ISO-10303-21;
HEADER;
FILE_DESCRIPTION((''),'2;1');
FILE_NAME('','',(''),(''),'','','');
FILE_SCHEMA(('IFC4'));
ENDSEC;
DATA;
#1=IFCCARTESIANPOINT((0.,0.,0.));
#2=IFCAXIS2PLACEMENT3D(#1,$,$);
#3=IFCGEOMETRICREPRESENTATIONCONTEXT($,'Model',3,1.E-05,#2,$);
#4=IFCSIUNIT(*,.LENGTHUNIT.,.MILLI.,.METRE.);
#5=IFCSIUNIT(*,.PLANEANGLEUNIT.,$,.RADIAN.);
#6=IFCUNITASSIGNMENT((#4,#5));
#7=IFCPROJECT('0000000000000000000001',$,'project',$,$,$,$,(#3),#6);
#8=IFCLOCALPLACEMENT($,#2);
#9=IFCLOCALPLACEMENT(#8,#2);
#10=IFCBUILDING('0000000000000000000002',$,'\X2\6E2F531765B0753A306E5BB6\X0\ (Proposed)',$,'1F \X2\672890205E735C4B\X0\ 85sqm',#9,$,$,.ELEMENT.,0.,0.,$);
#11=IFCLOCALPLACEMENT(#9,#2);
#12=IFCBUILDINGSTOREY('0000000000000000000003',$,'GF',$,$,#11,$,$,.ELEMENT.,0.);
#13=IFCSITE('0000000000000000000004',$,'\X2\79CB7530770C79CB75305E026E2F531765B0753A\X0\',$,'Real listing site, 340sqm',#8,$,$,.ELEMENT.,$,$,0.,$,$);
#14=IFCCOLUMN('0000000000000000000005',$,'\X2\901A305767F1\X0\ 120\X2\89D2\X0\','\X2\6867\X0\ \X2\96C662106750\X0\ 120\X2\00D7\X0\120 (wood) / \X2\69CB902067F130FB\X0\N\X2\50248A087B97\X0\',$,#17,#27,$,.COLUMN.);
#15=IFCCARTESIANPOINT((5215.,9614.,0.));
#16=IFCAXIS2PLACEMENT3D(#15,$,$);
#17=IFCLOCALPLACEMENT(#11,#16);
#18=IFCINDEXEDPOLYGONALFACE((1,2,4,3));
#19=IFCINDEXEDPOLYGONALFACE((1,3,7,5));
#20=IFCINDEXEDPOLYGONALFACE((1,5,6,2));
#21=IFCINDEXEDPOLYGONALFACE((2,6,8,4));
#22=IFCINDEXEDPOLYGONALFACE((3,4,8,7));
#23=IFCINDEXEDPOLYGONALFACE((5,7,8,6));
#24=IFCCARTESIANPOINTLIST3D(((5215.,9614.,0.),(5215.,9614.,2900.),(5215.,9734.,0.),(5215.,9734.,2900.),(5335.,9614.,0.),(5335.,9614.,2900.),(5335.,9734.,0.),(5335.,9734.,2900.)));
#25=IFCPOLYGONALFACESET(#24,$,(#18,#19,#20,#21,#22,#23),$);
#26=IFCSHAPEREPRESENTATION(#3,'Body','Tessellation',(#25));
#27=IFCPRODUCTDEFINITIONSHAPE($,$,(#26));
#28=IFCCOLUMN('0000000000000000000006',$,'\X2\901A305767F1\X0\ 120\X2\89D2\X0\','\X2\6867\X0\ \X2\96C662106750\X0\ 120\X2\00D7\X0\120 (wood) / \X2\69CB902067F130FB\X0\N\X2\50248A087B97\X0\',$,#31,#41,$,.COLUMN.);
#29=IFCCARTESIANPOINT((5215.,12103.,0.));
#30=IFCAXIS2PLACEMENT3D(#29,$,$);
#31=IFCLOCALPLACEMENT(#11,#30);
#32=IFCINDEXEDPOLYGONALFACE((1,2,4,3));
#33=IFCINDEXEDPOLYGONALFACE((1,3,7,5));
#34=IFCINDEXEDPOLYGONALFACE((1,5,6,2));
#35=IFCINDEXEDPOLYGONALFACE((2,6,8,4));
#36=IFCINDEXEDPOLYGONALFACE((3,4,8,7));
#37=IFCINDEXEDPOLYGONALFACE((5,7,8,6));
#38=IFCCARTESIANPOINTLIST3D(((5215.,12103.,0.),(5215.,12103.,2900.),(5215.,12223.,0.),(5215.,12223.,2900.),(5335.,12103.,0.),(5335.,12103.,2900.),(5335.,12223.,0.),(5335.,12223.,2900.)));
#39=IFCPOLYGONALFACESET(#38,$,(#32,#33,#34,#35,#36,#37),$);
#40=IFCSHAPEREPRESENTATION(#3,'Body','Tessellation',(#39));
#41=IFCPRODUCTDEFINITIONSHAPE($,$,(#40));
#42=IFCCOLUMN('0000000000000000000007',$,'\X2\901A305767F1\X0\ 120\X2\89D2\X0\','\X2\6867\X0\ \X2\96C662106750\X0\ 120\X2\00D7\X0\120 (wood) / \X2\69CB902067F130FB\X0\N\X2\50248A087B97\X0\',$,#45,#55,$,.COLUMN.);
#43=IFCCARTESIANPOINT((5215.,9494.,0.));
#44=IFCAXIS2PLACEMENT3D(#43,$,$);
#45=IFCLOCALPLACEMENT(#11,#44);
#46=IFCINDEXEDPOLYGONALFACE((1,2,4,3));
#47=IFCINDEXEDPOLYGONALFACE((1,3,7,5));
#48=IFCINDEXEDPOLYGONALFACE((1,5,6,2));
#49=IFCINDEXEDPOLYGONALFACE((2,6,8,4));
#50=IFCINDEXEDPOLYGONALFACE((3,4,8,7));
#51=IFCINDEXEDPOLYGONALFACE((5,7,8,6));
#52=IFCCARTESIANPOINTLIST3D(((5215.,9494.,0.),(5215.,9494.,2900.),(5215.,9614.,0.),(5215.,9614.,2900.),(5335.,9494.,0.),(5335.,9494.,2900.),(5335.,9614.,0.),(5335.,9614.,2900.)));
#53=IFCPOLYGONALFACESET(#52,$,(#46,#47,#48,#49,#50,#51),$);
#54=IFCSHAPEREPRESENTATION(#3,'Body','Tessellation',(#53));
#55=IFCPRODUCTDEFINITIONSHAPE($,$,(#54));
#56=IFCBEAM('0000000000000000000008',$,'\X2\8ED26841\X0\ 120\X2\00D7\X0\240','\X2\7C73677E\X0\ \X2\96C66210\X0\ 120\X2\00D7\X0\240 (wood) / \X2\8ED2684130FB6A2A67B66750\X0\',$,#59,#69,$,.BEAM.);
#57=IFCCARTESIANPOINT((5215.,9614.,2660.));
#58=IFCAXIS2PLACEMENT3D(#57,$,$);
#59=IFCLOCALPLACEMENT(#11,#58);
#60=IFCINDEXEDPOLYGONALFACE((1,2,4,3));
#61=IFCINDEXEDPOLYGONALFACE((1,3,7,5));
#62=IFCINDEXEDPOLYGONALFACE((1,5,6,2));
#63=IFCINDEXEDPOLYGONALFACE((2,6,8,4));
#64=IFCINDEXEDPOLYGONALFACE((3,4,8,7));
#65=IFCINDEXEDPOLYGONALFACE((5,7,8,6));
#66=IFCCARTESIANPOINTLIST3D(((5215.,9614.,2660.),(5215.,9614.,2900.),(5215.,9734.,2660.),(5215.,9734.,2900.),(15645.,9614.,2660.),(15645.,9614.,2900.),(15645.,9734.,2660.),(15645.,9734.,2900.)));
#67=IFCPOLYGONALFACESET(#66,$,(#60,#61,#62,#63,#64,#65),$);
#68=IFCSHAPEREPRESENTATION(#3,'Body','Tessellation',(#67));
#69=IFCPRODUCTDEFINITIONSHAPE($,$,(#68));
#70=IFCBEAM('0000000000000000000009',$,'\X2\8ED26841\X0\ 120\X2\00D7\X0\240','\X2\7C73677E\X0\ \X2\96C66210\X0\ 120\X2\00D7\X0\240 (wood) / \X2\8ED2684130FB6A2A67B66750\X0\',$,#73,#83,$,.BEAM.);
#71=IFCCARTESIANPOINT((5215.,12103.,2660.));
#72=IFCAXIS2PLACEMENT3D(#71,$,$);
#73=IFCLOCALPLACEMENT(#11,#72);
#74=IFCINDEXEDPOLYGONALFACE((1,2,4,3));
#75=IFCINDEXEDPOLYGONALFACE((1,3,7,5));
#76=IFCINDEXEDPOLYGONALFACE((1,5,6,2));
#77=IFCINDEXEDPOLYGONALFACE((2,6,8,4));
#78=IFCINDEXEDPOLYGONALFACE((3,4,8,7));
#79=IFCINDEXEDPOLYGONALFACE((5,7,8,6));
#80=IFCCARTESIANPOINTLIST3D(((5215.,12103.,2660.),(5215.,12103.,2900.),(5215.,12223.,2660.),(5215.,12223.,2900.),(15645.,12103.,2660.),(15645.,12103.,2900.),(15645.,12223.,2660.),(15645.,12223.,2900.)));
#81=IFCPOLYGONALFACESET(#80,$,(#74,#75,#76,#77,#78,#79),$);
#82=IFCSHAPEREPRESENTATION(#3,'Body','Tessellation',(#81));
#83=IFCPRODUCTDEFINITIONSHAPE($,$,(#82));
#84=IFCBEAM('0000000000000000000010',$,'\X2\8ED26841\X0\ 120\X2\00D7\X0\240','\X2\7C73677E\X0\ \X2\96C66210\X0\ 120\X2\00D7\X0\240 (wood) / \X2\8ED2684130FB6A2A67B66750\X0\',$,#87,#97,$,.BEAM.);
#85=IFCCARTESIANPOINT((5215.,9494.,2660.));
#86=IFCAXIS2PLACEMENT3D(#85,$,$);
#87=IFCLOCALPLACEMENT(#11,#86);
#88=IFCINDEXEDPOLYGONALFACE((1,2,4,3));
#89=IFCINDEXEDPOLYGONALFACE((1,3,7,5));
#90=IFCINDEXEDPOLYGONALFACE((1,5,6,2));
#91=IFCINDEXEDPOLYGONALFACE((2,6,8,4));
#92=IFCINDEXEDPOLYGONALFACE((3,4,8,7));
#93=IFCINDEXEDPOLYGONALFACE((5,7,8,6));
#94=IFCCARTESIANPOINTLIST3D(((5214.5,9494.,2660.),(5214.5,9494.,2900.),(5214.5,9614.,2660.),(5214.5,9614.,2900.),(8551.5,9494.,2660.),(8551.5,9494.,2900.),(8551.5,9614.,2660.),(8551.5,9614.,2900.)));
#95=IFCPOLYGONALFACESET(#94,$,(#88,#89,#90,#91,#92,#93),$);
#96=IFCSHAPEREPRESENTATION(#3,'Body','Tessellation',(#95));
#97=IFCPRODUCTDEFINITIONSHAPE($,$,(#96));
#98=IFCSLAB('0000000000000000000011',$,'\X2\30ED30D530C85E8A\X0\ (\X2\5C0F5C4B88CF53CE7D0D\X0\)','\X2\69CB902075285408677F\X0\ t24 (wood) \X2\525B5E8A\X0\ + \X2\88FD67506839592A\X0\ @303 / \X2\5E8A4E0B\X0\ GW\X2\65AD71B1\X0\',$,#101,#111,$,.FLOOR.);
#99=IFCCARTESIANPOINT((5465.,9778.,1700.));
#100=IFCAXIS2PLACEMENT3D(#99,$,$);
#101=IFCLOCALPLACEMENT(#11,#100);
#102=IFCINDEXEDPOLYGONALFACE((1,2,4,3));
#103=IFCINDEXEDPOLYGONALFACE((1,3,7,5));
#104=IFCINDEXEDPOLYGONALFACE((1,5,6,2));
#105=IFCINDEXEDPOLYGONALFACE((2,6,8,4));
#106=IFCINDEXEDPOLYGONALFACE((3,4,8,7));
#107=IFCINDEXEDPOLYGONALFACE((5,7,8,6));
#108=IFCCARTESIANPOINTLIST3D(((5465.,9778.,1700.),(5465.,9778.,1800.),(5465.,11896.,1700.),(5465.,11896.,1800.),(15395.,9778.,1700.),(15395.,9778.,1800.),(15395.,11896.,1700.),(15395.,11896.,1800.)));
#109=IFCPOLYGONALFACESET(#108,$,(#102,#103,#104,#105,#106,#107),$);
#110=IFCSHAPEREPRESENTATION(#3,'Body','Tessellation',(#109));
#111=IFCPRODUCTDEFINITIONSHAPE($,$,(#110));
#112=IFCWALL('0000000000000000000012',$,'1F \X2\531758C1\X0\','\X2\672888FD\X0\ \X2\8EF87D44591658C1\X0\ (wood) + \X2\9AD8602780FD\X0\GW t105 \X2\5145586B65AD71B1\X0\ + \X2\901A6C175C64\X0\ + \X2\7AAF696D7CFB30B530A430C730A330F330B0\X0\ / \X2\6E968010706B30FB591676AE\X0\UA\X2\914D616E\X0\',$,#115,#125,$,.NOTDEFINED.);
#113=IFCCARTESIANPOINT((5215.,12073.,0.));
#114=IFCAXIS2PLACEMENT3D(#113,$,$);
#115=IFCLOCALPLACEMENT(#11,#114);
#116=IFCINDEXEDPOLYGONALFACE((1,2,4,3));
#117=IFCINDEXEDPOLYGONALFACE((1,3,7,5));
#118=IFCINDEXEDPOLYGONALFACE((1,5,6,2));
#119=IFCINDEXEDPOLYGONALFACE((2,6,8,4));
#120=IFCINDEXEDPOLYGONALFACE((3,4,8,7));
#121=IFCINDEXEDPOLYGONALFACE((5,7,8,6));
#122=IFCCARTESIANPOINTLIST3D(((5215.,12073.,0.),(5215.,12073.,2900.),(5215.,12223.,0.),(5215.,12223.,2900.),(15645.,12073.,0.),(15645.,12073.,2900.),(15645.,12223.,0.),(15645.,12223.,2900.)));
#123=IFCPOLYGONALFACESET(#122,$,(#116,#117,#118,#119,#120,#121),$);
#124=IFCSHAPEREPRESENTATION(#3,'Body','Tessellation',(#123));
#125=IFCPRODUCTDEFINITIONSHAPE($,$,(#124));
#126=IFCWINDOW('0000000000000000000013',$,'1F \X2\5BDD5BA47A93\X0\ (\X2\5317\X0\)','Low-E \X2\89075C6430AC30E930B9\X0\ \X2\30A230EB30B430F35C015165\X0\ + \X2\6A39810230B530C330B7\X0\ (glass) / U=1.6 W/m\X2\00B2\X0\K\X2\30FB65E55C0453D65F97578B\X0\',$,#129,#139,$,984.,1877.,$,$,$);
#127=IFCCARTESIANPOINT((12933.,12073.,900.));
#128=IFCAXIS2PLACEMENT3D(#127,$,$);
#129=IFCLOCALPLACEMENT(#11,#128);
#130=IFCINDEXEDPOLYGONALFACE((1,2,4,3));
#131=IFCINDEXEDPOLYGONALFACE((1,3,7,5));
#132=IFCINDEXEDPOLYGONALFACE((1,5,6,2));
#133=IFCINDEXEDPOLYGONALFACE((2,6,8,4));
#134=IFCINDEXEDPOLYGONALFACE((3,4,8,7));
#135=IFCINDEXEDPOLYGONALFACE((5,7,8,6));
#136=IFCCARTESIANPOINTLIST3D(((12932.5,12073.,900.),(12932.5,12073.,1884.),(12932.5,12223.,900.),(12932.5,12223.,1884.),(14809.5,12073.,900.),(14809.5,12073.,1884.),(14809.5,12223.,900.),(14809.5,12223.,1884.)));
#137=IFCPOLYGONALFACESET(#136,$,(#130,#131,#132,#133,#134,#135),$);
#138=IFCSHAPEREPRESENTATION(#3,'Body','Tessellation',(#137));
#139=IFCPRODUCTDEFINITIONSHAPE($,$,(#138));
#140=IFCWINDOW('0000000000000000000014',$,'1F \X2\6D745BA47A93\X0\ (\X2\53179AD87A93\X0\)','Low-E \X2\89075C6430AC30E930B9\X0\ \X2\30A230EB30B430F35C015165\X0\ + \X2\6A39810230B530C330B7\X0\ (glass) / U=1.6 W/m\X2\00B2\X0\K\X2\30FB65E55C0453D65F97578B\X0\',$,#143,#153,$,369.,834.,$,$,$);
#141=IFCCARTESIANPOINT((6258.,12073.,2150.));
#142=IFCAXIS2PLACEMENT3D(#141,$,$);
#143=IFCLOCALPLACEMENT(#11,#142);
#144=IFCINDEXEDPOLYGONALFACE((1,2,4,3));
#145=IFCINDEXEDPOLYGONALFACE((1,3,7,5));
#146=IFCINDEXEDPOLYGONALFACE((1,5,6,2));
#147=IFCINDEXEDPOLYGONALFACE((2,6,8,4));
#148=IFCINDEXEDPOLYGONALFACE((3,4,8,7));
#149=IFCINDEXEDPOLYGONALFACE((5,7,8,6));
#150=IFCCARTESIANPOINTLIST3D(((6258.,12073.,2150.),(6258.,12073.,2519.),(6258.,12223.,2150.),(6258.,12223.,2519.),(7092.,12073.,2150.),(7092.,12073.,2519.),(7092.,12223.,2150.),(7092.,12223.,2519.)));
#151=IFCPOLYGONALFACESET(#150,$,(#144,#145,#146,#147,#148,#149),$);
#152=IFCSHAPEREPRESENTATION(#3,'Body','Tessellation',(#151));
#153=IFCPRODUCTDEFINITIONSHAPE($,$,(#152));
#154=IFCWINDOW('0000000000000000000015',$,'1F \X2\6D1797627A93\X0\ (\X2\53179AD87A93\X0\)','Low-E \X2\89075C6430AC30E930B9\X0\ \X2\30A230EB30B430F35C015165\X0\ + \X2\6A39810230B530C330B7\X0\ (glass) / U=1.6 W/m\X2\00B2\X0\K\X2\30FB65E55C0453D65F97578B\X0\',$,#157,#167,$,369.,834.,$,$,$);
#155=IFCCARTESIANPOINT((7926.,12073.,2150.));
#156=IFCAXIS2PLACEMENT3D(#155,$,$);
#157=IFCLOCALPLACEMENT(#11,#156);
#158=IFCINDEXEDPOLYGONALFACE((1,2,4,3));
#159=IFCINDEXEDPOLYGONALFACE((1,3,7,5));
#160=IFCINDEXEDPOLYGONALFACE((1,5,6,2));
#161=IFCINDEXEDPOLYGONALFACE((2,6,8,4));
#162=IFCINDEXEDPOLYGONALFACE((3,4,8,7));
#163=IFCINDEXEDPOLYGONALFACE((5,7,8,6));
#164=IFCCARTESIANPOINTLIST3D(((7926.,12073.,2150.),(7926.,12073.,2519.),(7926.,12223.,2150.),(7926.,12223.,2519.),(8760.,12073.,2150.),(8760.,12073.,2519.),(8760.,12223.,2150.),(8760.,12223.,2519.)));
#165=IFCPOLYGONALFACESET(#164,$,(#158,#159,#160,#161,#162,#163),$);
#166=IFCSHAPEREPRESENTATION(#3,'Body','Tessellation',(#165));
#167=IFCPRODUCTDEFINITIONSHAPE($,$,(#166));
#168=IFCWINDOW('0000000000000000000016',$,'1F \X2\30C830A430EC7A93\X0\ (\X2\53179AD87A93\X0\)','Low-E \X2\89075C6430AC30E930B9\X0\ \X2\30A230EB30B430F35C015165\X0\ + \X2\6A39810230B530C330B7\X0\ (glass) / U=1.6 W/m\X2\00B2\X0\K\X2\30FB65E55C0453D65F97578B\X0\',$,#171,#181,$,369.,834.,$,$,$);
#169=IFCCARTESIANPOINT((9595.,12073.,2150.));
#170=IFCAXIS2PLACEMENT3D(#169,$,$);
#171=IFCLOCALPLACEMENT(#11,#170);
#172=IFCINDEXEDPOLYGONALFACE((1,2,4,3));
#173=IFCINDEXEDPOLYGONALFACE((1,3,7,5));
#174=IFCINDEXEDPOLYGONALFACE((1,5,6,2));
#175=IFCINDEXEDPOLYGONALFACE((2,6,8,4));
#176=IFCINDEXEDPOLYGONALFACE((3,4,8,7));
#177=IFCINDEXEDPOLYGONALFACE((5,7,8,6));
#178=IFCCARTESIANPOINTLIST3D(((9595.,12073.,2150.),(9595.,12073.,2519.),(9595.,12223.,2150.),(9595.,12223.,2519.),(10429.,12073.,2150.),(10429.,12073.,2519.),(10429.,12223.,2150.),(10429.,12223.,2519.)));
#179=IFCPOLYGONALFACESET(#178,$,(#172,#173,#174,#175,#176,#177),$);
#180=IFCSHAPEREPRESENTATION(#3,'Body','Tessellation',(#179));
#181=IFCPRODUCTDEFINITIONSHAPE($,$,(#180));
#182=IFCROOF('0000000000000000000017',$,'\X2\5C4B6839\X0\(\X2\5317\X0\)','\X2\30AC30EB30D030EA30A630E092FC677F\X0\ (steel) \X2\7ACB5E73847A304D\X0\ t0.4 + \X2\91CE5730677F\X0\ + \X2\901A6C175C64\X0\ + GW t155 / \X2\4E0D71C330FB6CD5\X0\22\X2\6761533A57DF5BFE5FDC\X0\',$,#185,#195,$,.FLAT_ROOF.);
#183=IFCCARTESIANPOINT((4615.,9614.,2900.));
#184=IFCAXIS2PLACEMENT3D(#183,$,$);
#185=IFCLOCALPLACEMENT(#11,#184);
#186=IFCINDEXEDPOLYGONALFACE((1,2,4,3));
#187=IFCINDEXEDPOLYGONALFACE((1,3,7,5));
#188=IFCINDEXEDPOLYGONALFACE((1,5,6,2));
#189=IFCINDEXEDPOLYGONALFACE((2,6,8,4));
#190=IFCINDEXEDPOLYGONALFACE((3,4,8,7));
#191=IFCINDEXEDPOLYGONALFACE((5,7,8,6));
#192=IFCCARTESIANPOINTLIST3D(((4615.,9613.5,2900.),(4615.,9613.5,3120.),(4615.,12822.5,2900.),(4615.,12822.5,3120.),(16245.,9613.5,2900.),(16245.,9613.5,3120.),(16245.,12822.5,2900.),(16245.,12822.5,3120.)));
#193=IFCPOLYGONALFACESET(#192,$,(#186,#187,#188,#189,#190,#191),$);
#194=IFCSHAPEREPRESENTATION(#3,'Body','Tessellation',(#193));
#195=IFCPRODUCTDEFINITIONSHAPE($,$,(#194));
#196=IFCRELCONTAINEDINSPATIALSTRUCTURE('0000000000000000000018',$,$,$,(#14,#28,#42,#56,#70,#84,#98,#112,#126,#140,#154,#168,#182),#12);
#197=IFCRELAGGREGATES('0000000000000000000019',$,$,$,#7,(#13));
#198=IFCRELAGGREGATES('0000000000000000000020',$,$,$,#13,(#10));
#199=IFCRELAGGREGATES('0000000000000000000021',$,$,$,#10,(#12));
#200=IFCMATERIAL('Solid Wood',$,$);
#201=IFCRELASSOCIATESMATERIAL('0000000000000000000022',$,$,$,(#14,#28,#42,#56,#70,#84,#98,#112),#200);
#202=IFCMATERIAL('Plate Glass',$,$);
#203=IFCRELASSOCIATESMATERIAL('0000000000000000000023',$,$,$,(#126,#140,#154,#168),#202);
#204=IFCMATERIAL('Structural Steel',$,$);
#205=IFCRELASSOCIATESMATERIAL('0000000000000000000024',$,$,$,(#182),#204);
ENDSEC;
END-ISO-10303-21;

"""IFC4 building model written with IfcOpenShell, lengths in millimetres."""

from ifc_helpers import new_model, si_unit, frame, frame_2d, origin, place, context, project, spatial, rectangle, extrude, material, element, fill, save


model = new_model("IFC4")

# Units and contexts
model_context = context("Model", 3, precision=1e-05, world=origin())
ifc_project = project(units=[si_unit("LENGTHUNIT", "METRE", prefix="MILLI"), si_unit("PLANEANGLEUNIT", "RADIAN")], contexts=[model_context])

# Site, building, storey
site_placement = place(None, origin())
site = spatial("IfcSite", under=ifc_project, at=site_placement, Name="秋田県秋田市港北新町", ObjectType="Real listing site, 340sqm", CompositionType="ELEMENT", RefElevation=0.0)
building_placement = place(site_placement, origin())
building = spatial("IfcBuilding", under=site, at=building_placement, Name="港北新町の家 (Proposed)", ObjectType="1F 木造平屋 85sqm", CompositionType="ELEMENT", ElevationOfRefHeight=0.0, ElevationOfTerrain=0.0)
storey_placement = place(building_placement, origin())
storey = spatial("IfcBuildingStorey", under=building, at=storey_placement, Name="GF", CompositionType="ELEMENT", Elevation=0.0)

# Columns
ifc_material_1 = material(Name="Solid Wood")
column_1_placement = place(storey_placement, frame((5215.0, 9614.0, 0.0)))
element("IfcColumn", 1, at=column_1_placement, inside=storey, material=ifc_material_1, Name="通し柱 120角", Description="桧 集成材 120×120 (wood) / 構造柱・N値計算", PredefinedType="COLUMN", context=model_context, shape_type="SweptSolid", body=[
    extrude(rectangle(XDim=120.0, YDim=120.0, at=frame_2d((60.0, 60.0))), frame((5215.0, 9614.0, 0.0)), (0.0, 0.0, 1.0), 2900.0),
])
column_2_placement = place(storey_placement, frame((5215.0, 12103.0, 0.0)))
element("IfcColumn", 2, at=column_2_placement, inside=storey, material=ifc_material_1, Name="通し柱 120角", Description="桧 集成材 120×120 (wood) / 構造柱・N値計算", PredefinedType="COLUMN", context=model_context, shape_type="SweptSolid", body=[
    extrude(rectangle(XDim=120.0, YDim=120.0, at=frame_2d((60.0, 60.0))), frame((5215.0, 12103.0, 0.0)), (0.0, 0.0, 1.0), 2900.0),
])
column_3_placement = place(storey_placement, frame((5215.0, 9494.0, 0.0)))
element("IfcColumn", 3, at=column_3_placement, inside=storey, material=ifc_material_1, Name="通し柱 120角", Description="桧 集成材 120×120 (wood) / 構造柱・N値計算", PredefinedType="COLUMN", context=model_context, shape_type="SweptSolid", body=[
    extrude(rectangle(XDim=120.0, YDim=120.0, at=frame_2d((60.0, 60.0))), frame((5215.0, 9494.0, 0.0)), (0.0, 0.0, 1.0), 2900.0),
])

# Beams
beam_1_placement = place(storey_placement, frame((5215.0, 9614.0, 2660.0)))
element("IfcBeam", 4, at=beam_1_placement, inside=storey, material=ifc_material_1, Name="軒桁 120×240", Description="米松 集成 120×240 (wood) / 軒桁・横架材", PredefinedType="BEAM", context=model_context, shape_type="SweptSolid", body=[
    extrude(rectangle(XDim=10430.0, YDim=120.0, at=frame_2d((5215.0, 60.0))), frame((5215.0, 9614.0, 2660.0)), (0.0, 0.0, 1.0), 240.0),
])
beam_2_placement = place(storey_placement, frame((5215.0, 12103.0, 2660.0)))
element("IfcBeam", 5, at=beam_2_placement, inside=storey, material=ifc_material_1, Name="軒桁 120×240", Description="米松 集成 120×240 (wood) / 軒桁・横架材", PredefinedType="BEAM", context=model_context, shape_type="SweptSolid", body=[
    extrude(rectangle(XDim=10430.0, YDim=120.0, at=frame_2d((5215.0, 60.0))), frame((5215.0, 12103.0, 2660.0)), (0.0, 0.0, 1.0), 240.0),
])
beam_3_placement = place(storey_placement, frame((5215.0, 9494.0, 2660.0)))
element("IfcBeam", 6, at=beam_3_placement, inside=storey, material=ifc_material_1, Name="軒桁 120×240", Description="米松 集成 120×240 (wood) / 軒桁・横架材", PredefinedType="BEAM", context=model_context, shape_type="SweptSolid", body=[
    extrude(rectangle(XDim=3337.0, YDim=120.0, at=frame_2d((1668.0, 60.0))), frame((5215.0, 9494.0, 2660.0)), (0.0, 0.0, 1.0), 240.0),
])

# Slab
slab_1_placement = place(storey_placement, frame((5465.0, 9778.0, 1700.0)))
element("IfcSlab", 7, at=slab_1_placement, inside=storey, material=ifc_material_1, Name="ロフト床 (小屋裏収納)", Description="構造用合板 t24 (wood) 剛床 + 製材根太 @303 / 床下 GW断熱", PredefinedType="FLOOR", context=model_context, shape_type="SweptSolid", body=[
    extrude(rectangle(XDim=9930.0, YDim=2118.0, at=frame_2d((4965.0, 1059.0))), frame((5465.0, 9778.0, 1700.0)), (0.0, 0.0, 1.0), 100.0),
])

# Wall, openings, windows
wall_1_placement = place(storey_placement, frame((5215.0, 12073.0, 0.0)))
wall_1 = element("IfcWall", 8, at=wall_1_placement, inside=storey, material=ifc_material_1, Name="1F 北壁", Description="木製 軸組外壁 (wood) + 高性能GW t105 充填断熱 + 通気層 + 窯業系サイディング / 準耐火・外皮UA配慮", PredefinedType="NOTDEFINED", context=model_context, shape_type="SweptSolid", body=[
    extrude(rectangle(XDim=10430.0, YDim=150.0, at=frame_2d((5215.0, 75.0))), frame((5215.0, 12073.0, 0.0)), (0.0, 0.0, 1.0), 2900.0),
])
opening_1_placement = place(storey_placement, frame((12933.0, 12073.0, 900.0)))
opening_1 = element("IfcOpeningElement", 9, at=opening_1_placement, cuts=wall_1, PredefinedType="NOTDEFINED", context=model_context, shape_type="SweptSolid", body=[
    extrude(rectangle(XDim=1877.0, YDim=150.0, at=frame_2d((938.0, 75.0))), frame((12933.0, 12073.0, 900.0)), (0.0, 0.0, 1.0), 984.0),
])
opening_2_placement = place(storey_placement, frame((6258.0, 12073.0, 2150.0)))
opening_2 = element("IfcOpeningElement", 10, at=opening_2_placement, cuts=wall_1, PredefinedType="NOTDEFINED", context=model_context, shape_type="SweptSolid", body=[
    extrude(rectangle(XDim=834.0, YDim=150.0, at=frame_2d((417.0, 75.0))), frame((6258.0, 12073.0, 2150.0)), (0.0, 0.0, 1.0), 369.0),
])
opening_3_placement = place(storey_placement, frame((7926.0, 12073.0, 2150.0)))
opening_3 = element("IfcOpeningElement", 11, at=opening_3_placement, cuts=wall_1, PredefinedType="NOTDEFINED", context=model_context, shape_type="SweptSolid", body=[
    extrude(rectangle(XDim=834.0, YDim=150.0, at=frame_2d((417.0, 75.0))), frame((7926.0, 12073.0, 2150.0)), (0.0, 0.0, 1.0), 369.0),
])
opening_4_placement = place(storey_placement, frame((9595.0, 12073.0, 2150.0)))
opening_4 = element("IfcOpeningElement", 12, at=opening_4_placement, cuts=wall_1, PredefinedType="NOTDEFINED", context=model_context, shape_type="SweptSolid", body=[
    extrude(rectangle(XDim=834.0, YDim=150.0, at=frame_2d((417.0, 75.0))), frame((9595.0, 12073.0, 2150.0)), (0.0, 0.0, 1.0), 369.0),
])
ifc_material_2 = material(Name="Plate Glass")
window_1_placement = place(storey_placement, frame((12933.0, 12073.0, 900.0)))
window_1 = element("IfcWindow", 13, at=window_1_placement, inside=storey, material=ifc_material_2, Name="1F 寝室窓 (北)", Description="Low-E 複層ガラス アルゴン封入 + 樹脂サッシ (glass) / U=1.6 W/m²K・日射取得型", OverallHeight=984.0, OverallWidth=1877.0, context=model_context, shape_type="SweptSolid", body=[
    extrude(rectangle(XDim=1877.0, YDim=150.0, at=frame_2d((938.0, 75.0))), frame((12933.0, 12073.0, 900.0)), (0.0, 0.0, 1.0), 984.0),
])
fill(opening_1, window_1)
window_2_placement = place(storey_placement, frame((6258.0, 12073.0, 2150.0)))
window_2 = element("IfcWindow", 14, at=window_2_placement, inside=storey, material=ifc_material_2, Name="1F 浴室窓 (北高窓)", Description="Low-E 複層ガラス アルゴン封入 + 樹脂サッシ (glass) / U=1.6 W/m²K・日射取得型", OverallHeight=369.0, OverallWidth=834.0, context=model_context, shape_type="SweptSolid", body=[
    extrude(rectangle(XDim=834.0, YDim=150.0, at=frame_2d((417.0, 75.0))), frame((6258.0, 12073.0, 2150.0)), (0.0, 0.0, 1.0), 369.0),
])
fill(opening_2, window_2)
window_3_placement = place(storey_placement, frame((7926.0, 12073.0, 2150.0)))
window_3 = element("IfcWindow", 15, at=window_3_placement, inside=storey, material=ifc_material_2, Name="1F 洗面窓 (北高窓)", Description="Low-E 複層ガラス アルゴン封入 + 樹脂サッシ (glass) / U=1.6 W/m²K・日射取得型", OverallHeight=369.0, OverallWidth=834.0, context=model_context, shape_type="SweptSolid", body=[
    extrude(rectangle(XDim=834.0, YDim=150.0, at=frame_2d((417.0, 75.0))), frame((7926.0, 12073.0, 2150.0)), (0.0, 0.0, 1.0), 369.0),
])
fill(opening_3, window_3)
window_4_placement = place(storey_placement, frame((9595.0, 12073.0, 2150.0)))
window_4 = element("IfcWindow", 16, at=window_4_placement, inside=storey, material=ifc_material_2, Name="1F トイレ窓 (北高窓)", Description="Low-E 複層ガラス アルゴン封入 + 樹脂サッシ (glass) / U=1.6 W/m²K・日射取得型", OverallHeight=369.0, OverallWidth=834.0, context=model_context, shape_type="SweptSolid", body=[
    extrude(rectangle(XDim=834.0, YDim=150.0, at=frame_2d((417.0, 75.0))), frame((9595.0, 12073.0, 2150.0)), (0.0, 0.0, 1.0), 369.0),
])
fill(opening_4, window_4)

# Roof
ifc_material_3 = material(Name="Structural Steel")
roof_placement = place(storey_placement, frame((4615.0, 9614.0, 2900.0)))
element("IfcRoof", 17, at=roof_placement, inside=storey, material=ifc_material_3, Name="屋根(北)", Description="ガルバリウム鋼板 (steel) 立平葺き t0.4 + 野地板 + 通気層 + GW t155 / 不燃・法22条区域対応", PredefinedType="FLAT_ROOF", context=model_context, shape_type="SweptSolid", body=[
    extrude(rectangle(XDim=11630.0, YDim=3209.0, at=frame_2d((5815.0, 1604.0))), frame((4615.0, 9614.0, 2900.0)), (0.0, 0.0, 1.0), 220.0),
])

save(model, "model.ifc")
